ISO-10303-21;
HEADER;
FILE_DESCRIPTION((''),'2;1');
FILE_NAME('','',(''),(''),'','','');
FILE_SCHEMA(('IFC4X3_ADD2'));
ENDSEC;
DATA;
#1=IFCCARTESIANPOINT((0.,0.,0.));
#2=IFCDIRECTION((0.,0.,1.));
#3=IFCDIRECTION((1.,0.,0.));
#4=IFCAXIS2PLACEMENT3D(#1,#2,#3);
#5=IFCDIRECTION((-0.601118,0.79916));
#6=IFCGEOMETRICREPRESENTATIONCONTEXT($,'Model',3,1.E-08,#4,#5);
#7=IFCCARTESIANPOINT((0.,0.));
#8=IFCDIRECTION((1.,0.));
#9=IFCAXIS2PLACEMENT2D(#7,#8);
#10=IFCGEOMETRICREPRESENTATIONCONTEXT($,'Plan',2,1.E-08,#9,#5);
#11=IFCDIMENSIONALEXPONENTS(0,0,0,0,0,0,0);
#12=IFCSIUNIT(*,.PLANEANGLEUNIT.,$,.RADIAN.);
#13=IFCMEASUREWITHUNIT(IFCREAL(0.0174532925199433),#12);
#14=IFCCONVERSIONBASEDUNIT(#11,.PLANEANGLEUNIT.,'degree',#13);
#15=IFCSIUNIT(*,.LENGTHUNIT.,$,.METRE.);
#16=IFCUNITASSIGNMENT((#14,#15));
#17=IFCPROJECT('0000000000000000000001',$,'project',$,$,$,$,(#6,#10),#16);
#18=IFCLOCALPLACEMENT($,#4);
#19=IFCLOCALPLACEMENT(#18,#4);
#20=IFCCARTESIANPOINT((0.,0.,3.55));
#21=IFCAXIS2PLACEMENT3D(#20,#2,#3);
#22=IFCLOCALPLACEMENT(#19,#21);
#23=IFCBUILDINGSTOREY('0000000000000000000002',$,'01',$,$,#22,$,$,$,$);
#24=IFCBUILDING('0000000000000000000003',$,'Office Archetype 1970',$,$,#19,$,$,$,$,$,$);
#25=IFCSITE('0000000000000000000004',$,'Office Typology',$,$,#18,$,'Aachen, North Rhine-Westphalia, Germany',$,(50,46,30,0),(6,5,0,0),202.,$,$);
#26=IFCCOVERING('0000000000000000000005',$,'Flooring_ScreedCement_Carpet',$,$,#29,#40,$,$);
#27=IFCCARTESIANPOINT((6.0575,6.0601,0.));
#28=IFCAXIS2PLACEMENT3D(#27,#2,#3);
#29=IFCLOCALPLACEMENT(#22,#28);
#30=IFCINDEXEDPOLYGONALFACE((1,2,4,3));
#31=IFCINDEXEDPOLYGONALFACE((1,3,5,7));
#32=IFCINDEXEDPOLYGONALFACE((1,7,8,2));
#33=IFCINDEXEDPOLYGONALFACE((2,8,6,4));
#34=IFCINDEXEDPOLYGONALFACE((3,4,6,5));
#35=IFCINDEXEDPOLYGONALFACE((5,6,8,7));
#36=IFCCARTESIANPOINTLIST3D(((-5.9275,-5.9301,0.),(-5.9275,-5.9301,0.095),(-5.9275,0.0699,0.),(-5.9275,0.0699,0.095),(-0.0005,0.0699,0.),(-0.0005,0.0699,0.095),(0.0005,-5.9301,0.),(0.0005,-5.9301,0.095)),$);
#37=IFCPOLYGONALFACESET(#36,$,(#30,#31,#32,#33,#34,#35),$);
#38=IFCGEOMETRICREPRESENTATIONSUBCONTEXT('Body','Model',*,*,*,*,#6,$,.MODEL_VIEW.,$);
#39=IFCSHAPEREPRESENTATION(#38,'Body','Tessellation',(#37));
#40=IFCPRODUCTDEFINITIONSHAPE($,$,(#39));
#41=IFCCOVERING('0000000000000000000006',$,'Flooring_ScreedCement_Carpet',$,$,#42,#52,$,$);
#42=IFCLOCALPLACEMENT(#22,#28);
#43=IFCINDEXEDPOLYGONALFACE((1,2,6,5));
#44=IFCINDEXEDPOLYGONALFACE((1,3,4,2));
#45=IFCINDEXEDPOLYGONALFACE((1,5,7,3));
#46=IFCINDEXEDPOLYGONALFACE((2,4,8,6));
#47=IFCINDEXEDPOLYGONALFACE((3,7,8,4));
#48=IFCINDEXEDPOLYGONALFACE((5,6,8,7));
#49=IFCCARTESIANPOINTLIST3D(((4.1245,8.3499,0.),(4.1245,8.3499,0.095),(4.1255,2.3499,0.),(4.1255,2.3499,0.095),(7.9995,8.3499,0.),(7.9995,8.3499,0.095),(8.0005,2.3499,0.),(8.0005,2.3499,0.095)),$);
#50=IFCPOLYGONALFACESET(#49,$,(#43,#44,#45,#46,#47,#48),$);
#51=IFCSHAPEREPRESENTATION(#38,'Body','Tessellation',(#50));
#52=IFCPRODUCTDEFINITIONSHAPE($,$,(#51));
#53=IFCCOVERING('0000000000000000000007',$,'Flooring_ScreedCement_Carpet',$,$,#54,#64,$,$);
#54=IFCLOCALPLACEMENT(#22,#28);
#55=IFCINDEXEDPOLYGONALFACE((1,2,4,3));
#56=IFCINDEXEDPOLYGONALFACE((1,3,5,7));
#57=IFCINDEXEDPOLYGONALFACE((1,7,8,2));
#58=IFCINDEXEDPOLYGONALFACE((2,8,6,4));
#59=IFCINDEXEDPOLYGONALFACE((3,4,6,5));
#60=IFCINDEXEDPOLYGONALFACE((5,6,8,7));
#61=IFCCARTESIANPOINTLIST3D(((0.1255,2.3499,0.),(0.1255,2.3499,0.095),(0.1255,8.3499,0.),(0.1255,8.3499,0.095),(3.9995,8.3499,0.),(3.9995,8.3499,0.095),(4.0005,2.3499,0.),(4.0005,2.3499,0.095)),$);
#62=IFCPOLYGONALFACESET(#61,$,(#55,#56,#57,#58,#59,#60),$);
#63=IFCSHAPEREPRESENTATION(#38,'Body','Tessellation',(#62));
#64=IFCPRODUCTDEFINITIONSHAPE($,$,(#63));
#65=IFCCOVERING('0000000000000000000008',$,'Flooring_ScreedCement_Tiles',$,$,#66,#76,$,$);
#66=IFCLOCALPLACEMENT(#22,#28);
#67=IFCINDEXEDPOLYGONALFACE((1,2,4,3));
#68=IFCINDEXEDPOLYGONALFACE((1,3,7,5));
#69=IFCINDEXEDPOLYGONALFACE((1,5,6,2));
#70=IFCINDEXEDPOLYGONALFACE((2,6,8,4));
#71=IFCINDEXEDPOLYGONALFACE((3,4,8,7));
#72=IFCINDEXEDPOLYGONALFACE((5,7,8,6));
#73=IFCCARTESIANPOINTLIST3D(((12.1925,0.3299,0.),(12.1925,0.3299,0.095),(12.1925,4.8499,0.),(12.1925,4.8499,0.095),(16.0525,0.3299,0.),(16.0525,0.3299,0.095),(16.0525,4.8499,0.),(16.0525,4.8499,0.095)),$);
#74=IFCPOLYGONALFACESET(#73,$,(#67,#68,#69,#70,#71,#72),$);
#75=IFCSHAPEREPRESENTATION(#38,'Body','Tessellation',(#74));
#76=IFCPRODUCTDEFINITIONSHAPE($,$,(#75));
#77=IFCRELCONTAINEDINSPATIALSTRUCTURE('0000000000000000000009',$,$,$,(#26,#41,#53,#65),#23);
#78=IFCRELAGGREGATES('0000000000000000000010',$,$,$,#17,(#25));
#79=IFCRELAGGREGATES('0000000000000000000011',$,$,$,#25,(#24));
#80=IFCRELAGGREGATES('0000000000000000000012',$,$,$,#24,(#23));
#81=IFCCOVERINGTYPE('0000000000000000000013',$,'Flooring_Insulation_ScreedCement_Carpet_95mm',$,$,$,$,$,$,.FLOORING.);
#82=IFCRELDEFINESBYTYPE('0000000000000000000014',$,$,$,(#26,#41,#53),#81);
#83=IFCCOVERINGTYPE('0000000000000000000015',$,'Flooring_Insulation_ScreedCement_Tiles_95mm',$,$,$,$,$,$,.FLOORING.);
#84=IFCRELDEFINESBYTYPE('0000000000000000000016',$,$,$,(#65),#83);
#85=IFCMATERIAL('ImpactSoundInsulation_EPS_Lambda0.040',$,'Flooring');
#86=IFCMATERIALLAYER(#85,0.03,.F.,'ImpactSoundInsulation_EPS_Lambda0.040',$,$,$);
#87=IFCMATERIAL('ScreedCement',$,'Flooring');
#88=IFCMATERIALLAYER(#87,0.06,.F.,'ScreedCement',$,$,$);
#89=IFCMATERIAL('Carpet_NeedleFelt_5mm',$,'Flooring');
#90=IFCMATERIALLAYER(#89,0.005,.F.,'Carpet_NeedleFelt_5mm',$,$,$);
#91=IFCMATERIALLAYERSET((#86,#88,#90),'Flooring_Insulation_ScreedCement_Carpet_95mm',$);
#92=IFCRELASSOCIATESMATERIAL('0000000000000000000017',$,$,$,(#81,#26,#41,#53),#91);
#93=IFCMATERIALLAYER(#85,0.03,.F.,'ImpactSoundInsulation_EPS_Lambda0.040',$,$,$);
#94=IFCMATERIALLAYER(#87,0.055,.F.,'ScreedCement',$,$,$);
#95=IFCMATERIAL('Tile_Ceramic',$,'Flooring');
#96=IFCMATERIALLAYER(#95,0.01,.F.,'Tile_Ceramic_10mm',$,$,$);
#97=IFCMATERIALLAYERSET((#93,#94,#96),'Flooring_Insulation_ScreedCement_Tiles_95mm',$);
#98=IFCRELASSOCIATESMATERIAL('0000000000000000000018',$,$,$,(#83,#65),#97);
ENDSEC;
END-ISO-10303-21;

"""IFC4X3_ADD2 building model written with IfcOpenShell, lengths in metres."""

from ifc_helpers import new_model, entity, si_unit, converted_unit, direction, frame, origin_with_axes, origin_2d_with_axis, place, context, subcontext, project, spatial, line, indexed_curve, outline, extrude, material, layer, layer_set, layer_usage, type_object, element, save


model = new_model("IFC4X3_ADD2")

# Units and contexts
model_context = context("Model", 3, precision=1e-08, world=origin_with_axes(), true_north=direction((-0.601118, 0.79916)))
plan_context = context("Plan", 2, precision=1e-08, world=origin_2d_with_axis(), true_north=direction((-0.601118, 0.79916)))
body_context = subcontext(model_context, "Body", "Model", "MODEL_VIEW")
ifc_project = project(units=[converted_unit("PLANEANGLEUNIT", "degree", entity("IfcReal", 0.0174532925199433), si_unit("PLANEANGLEUNIT", "RADIAN"), dimensions=[0, 0, 0, 0, 0, 0, 0]), si_unit("LENGTHUNIT", "METRE")], contexts=[model_context, plan_context])

# Site, building, storey
site_placement = place(None, origin_with_axes())
site = spatial("IfcSite", under=ifc_project, at=site_placement, Name="Office Typology", LongName="Aachen, North Rhine-Westphalia, Germany", RefLatitude=(50, 46, 30, 0), RefLongitude=(6, 5, 0, 0), RefElevation=202.0)
building_placement = place(site_placement, origin_with_axes())
building = spatial("IfcBuilding", under=site, at=building_placement, Name="Office Archetype 1970")
storey_placement = place(building_placement, frame((0.0, 0.0, 3.55), z_axis=(0.0, 0.0, 1.0), x_axis=(1.0, 0.0, 0.0)))
storey = spatial("IfcBuildingStorey", under=building, at=storey_placement, Name="01")

# Coverings
ifc_material_1 = material(Name="ImpactSoundInsulation_EPS_Lambda0.040", Category="Flooring")
ifc_layer_1 = layer(ifc_material_1, 0.03, ventilated=False, Name="ImpactSoundInsulation_EPS_Lambda0.040")
ifc_material_2 = material(Name="ScreedCement", Category="Flooring")
ifc_layer_2 = layer(ifc_material_2, 0.06, ventilated=False, Name="ScreedCement")
ifc_material_3 = material(Name="Carpet_NeedleFelt_5mm", Category="Flooring")
ifc_layer_3 = layer(ifc_material_3, 0.005, ventilated=False, Name="Carpet_NeedleFelt_5mm")
ifc_layer_set_1 = layer_set([ifc_layer_1, ifc_layer_2, ifc_layer_3], Name="Flooring_Insulation_ScreedCement_Carpet_95mm")
ifc_layer_usage_1 = layer_usage(ifc_layer_set_1, "AXIS3", "POSITIVE", 0.0)
covering_type_1 = type_object("IfcCoveringType", Name="Flooring_Insulation_ScreedCement_Carpet_95mm", PredefinedType="FLOORING", material=ifc_layer_set_1)
covering_1_placement = place(storey_placement, frame((6.0575, 6.0601, 0.0), z_axis=(0.0, 0.0, 1.0), x_axis=(1.0, 0.0, 0.0)))
element("IfcCovering", 1, at=covering_1_placement, inside=storey, type_object=covering_type_1, material=ifc_layer_usage_1, Name="Flooring_ScreedCement_Carpet", context=body_context, shape_type="SweptSolid", body=[
    extrude(outline(indexed_curve([(-5.9275, -5.9301), (-5.9275, 0.0699), (-0.0005, 0.0699), (0.0005, -5.9301)], segments=[line(1, 2, 3, 4, 1)])), origin_with_axes(), (0.0, 0.0, 1.0), 0.095),
])
ifc_layer_usage_2 = layer_usage(ifc_layer_set_1, "AXIS3", "POSITIVE", 0.0)
covering_2_placement = place(storey_placement, frame((6.0575, 6.0601, 0.0), z_axis=(0.0, 0.0, 1.0), x_axis=(1.0, 0.0, 0.0)))
element("IfcCovering", 2, at=covering_2_placement, inside=storey, type_object=covering_type_1, material=ifc_layer_usage_2, Name="Flooring_ScreedCement_Carpet", context=body_context, shape_type="SweptSolid", body=[
    extrude(outline(indexed_curve([(4.1255, 2.3499), (4.1245, 8.3499), (7.9995, 8.3499), (8.0005, 2.3499)], segments=[line(1, 2, 3, 4, 1)])), origin_with_axes(), (0.0, 0.0, 1.0), 0.095),
])
ifc_layer_usage_3 = layer_usage(ifc_layer_set_1, "AXIS3", "POSITIVE", 0.0)
covering_3_placement = place(storey_placement, frame((6.0575, 6.0601, 0.0), z_axis=(0.0, 0.0, 1.0), x_axis=(1.0, 0.0, 0.0)))
element("IfcCovering", 3, at=covering_3_placement, inside=storey, type_object=covering_type_1, material=ifc_layer_usage_3, Name="Flooring_ScreedCement_Carpet", context=body_context, shape_type="SweptSolid", body=[
    extrude(outline(indexed_curve([(0.1255, 2.3499), (0.1255, 8.3499), (3.9995, 8.3499), (4.0005, 2.3499)], segments=[line(1, 2, 3, 4, 1)])), origin_with_axes(), (0.0, 0.0, 1.0), 0.095),
])
ifc_layer_4 = layer(ifc_material_1, 0.03, ventilated=False, Name="ImpactSoundInsulation_EPS_Lambda0.040")
ifc_layer_5 = layer(ifc_material_2, 0.055, ventilated=False, Name="ScreedCement")
ifc_material_4 = material(Name="Tile_Ceramic", Category="Flooring")
ifc_layer_6 = layer(ifc_material_4, 0.01, ventilated=False, Name="Tile_Ceramic_10mm")
ifc_layer_set_2 = layer_set([ifc_layer_4, ifc_layer_5, ifc_layer_6], Name="Flooring_Insulation_ScreedCement_Tiles_95mm")
ifc_layer_usage_4 = layer_usage(ifc_layer_set_2, "AXIS3", "POSITIVE", 0.0)
covering_type_2 = type_object("IfcCoveringType", Name="Flooring_Insulation_ScreedCement_Tiles_95mm", PredefinedType="FLOORING", material=ifc_layer_set_2)
covering_4_placement = place(storey_placement, frame((6.0575, 6.0601, 0.0), z_axis=(0.0, 0.0, 1.0), x_axis=(1.0, 0.0, 0.0)))
element("IfcCovering", 4, at=covering_4_placement, inside=storey, type_object=covering_type_2, material=ifc_layer_usage_4, Name="Flooring_ScreedCement_Tiles", context=body_context, shape_type="SweptSolid", body=[
    extrude(outline(indexed_curve([(12.1925, 0.3299), (12.1925, 4.8499), (16.0525, 4.8499), (16.0525, 0.3299)], segments=[line(1, 2, 3, 4, 1)])), origin_with_axes(), (0.0, 0.0, 1.0), 0.095),
])

save(model, "model.ifc")
